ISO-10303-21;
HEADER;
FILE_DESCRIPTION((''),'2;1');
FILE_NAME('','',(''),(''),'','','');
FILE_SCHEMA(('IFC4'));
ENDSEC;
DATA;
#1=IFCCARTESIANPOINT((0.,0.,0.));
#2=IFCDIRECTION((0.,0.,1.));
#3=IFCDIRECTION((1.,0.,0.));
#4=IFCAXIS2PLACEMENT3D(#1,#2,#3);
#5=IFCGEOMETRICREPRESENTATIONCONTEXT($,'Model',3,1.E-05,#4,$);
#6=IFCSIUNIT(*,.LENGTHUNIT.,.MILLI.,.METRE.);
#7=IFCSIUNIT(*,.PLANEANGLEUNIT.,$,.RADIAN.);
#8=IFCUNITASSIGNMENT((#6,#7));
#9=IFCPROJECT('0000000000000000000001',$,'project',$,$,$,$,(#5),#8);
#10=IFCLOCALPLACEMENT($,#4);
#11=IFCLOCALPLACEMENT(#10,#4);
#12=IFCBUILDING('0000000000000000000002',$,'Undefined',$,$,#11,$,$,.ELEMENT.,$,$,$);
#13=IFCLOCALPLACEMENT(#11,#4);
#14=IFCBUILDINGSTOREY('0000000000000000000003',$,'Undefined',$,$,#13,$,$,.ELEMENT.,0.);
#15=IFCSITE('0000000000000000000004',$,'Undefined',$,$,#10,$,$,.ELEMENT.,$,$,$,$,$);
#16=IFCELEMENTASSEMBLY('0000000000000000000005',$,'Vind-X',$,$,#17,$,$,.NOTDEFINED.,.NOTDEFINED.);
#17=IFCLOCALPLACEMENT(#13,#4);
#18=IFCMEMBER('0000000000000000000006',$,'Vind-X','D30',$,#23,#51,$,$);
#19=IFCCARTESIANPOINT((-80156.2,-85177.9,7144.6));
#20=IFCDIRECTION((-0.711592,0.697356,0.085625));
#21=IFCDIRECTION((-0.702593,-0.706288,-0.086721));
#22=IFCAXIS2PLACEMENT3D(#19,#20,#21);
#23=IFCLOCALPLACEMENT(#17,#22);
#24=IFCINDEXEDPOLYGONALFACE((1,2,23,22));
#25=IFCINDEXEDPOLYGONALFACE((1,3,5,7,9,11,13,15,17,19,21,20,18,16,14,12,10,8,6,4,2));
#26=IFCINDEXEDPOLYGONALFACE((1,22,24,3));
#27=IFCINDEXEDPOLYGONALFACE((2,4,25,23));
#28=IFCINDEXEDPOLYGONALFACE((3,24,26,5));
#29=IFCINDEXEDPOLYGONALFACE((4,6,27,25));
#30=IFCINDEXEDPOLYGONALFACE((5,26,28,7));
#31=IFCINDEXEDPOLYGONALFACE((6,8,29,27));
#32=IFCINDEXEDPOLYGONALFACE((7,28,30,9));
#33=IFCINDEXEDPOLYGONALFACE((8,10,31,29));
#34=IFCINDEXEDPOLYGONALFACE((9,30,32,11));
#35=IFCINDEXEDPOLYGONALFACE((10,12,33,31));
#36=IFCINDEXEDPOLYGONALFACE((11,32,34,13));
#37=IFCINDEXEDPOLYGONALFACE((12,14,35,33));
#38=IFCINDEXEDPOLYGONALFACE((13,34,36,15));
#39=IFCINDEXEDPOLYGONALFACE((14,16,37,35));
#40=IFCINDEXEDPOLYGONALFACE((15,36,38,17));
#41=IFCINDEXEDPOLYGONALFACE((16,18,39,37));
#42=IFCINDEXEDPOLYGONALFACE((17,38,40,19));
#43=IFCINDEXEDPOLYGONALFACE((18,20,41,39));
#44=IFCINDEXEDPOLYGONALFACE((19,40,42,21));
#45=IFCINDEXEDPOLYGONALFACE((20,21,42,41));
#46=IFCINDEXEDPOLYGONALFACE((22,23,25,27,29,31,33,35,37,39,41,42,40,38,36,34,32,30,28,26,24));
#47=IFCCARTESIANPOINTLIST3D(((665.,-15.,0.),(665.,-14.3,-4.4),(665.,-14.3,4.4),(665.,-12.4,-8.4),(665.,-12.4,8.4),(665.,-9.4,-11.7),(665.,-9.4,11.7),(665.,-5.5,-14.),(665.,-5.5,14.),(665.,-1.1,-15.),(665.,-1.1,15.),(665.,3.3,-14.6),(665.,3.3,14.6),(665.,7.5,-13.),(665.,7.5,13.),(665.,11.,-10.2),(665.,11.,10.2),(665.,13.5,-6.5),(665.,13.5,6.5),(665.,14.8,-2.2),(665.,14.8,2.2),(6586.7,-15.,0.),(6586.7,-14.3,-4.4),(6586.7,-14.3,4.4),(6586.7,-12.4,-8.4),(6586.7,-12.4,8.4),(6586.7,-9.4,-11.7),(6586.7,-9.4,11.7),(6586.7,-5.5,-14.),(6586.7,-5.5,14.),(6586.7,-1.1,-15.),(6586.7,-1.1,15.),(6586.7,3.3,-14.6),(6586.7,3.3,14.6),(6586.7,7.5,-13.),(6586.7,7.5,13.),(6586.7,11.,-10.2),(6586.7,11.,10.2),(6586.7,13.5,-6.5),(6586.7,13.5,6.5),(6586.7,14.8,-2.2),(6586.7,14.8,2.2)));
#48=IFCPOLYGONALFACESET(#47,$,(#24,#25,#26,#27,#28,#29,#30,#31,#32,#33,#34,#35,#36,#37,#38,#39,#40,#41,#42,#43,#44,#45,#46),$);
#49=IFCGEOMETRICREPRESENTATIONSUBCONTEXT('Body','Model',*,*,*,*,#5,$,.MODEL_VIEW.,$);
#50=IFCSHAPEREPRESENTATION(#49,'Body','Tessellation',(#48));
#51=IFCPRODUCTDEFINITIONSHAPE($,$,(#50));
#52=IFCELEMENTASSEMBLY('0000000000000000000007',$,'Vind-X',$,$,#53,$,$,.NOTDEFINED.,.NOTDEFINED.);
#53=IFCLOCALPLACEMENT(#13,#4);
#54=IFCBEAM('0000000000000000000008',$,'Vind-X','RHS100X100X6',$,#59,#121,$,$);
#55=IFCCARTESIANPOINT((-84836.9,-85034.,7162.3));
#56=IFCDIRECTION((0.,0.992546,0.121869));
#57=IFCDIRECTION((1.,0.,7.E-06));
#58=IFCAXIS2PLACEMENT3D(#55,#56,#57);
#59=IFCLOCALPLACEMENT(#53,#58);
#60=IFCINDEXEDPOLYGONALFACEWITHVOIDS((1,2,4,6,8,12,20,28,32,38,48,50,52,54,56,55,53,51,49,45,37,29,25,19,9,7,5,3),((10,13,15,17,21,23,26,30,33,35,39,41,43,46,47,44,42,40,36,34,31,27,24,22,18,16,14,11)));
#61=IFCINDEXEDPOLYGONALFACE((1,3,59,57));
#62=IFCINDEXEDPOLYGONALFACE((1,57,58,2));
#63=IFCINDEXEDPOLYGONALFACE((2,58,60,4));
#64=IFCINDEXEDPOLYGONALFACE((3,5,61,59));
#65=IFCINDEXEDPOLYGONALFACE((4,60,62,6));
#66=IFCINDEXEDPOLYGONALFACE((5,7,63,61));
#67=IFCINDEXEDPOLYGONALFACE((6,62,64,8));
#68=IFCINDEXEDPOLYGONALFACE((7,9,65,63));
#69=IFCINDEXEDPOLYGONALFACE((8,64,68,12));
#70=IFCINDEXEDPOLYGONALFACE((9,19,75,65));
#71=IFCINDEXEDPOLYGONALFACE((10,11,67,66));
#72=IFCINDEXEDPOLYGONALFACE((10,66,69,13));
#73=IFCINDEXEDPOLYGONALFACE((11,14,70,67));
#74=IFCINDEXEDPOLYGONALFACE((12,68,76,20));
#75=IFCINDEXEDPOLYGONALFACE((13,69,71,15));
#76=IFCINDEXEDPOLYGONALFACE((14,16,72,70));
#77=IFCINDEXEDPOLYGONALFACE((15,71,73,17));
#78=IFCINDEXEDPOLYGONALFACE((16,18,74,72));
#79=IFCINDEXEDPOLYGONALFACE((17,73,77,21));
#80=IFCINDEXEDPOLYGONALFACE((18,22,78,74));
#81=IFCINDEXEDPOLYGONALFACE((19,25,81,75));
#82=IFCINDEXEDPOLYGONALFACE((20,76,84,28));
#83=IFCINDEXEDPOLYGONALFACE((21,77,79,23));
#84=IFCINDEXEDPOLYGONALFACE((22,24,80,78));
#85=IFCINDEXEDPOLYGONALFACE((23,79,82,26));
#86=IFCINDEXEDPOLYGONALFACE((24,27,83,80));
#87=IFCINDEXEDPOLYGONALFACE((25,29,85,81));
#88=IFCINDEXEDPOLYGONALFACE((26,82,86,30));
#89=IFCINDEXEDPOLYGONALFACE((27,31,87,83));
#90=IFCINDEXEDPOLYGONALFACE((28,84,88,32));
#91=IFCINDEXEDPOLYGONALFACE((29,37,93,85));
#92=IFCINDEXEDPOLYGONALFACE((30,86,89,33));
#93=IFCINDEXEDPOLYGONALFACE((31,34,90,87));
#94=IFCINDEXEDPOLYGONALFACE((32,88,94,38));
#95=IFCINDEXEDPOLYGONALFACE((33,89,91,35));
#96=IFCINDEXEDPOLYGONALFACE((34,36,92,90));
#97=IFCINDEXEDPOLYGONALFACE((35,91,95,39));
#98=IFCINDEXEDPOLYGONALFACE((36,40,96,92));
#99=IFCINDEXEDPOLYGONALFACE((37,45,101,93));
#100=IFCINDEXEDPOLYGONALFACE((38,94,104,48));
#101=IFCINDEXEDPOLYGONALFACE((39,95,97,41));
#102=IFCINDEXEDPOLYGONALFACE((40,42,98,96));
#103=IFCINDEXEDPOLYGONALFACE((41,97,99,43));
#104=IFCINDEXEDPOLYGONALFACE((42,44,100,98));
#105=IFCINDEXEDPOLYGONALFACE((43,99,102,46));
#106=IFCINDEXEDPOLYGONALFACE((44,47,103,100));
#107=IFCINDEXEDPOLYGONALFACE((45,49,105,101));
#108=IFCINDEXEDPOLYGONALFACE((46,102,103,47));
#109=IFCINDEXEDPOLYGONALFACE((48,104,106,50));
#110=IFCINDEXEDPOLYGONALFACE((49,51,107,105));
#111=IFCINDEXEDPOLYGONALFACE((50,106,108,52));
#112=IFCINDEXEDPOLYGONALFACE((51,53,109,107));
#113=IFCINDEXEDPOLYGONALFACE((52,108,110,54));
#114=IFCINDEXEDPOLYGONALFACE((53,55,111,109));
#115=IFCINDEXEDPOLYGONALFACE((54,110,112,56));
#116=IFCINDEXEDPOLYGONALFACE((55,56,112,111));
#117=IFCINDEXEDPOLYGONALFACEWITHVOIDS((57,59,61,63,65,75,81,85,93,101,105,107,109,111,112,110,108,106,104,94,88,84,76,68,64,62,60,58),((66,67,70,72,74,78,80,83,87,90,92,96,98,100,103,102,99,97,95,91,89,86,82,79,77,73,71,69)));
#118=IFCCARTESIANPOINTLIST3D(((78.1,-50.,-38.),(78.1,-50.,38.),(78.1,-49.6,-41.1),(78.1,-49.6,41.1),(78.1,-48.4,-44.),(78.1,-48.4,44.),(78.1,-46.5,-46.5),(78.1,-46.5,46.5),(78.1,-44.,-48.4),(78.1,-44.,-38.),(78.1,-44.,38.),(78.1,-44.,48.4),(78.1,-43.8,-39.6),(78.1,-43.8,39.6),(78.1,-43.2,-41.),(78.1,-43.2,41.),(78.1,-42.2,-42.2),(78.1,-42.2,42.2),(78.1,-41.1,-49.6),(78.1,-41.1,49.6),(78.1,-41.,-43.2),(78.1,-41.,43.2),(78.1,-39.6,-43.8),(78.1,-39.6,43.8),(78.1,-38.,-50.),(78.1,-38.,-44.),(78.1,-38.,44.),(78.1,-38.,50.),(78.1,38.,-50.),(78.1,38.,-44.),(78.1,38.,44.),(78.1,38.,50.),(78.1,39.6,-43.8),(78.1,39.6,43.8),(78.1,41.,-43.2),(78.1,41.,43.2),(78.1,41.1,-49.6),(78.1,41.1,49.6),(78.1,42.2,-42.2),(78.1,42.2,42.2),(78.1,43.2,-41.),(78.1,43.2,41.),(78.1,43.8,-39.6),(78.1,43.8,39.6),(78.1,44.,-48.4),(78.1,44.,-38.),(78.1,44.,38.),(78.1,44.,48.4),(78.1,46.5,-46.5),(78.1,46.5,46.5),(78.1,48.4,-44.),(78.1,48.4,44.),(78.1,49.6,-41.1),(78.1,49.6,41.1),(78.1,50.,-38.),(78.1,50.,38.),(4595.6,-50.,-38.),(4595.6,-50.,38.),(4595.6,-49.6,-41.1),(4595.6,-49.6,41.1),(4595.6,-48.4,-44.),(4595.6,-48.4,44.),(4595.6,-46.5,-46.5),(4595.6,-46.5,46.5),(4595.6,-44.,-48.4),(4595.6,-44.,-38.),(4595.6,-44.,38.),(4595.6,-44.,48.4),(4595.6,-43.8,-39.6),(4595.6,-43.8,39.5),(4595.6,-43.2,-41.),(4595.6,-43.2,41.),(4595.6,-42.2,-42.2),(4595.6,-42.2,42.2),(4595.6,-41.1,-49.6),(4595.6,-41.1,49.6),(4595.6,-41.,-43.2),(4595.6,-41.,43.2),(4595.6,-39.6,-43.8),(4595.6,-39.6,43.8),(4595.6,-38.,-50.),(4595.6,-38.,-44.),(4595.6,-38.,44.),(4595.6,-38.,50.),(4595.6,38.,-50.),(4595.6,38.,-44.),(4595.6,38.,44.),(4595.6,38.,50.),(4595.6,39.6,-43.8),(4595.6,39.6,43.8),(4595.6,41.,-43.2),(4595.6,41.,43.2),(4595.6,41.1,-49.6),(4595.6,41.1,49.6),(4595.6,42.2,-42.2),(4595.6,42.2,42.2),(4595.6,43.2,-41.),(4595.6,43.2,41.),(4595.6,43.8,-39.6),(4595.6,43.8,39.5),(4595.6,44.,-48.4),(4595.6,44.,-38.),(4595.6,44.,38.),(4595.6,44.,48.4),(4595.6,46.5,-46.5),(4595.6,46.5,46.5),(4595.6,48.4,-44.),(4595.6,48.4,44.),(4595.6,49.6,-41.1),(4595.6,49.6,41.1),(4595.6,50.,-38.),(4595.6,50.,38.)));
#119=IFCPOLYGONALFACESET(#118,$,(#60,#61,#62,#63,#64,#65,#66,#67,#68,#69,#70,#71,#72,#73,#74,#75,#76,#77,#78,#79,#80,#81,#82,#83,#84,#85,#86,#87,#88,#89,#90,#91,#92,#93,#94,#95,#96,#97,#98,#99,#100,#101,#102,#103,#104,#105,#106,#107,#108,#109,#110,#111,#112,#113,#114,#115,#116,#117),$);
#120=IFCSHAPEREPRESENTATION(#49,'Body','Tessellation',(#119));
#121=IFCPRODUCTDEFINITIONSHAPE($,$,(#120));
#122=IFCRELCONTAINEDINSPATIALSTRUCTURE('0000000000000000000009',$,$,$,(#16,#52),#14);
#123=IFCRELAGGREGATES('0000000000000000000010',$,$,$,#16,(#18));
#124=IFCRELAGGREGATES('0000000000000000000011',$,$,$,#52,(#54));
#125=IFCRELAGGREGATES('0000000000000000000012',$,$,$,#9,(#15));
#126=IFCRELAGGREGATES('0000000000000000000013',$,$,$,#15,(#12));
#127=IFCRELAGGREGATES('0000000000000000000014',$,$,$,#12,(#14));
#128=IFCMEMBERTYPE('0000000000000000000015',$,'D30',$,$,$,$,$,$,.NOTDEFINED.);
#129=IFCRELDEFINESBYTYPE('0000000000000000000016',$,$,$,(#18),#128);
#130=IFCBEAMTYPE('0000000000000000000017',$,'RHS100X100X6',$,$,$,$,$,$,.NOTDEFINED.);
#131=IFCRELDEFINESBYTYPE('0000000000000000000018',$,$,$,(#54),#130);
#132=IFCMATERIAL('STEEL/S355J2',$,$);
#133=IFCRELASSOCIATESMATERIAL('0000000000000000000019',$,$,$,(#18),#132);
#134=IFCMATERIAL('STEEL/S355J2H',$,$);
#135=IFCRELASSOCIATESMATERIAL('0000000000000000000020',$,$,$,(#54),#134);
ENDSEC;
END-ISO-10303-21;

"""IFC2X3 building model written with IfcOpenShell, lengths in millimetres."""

from ifc_helpers import new_model, si_unit, frame, origin_with_axes, origin_2d_with_axis, place, context, subcontext, project, spatial, hollow_rectangle, circle, extrude, clip, halfspace, material, type_object, element, aggregate, save


model = new_model("IFC2X3")

# Units and contexts
model_context = context("Model", 3, precision=1e-05, world=origin_with_axes())
body_context = subcontext(model_context, "Body", "Model", "MODEL_VIEW")
ifc_project = project(units=[si_unit("LENGTHUNIT", "METRE", prefix="MILLI"), si_unit("PLANEANGLEUNIT", "RADIAN")], contexts=[model_context])

# Site, building, storey
site_placement = place(None, origin_with_axes())
site = spatial("IfcSite", under=ifc_project, at=site_placement, Name="Undefined", CompositionType="ELEMENT")
building_placement = place(site_placement, origin_with_axes())
building = spatial("IfcBuilding", under=site, at=building_placement, Name="Undefined", CompositionType="ELEMENT")
storey_placement = place(building_placement, origin_with_axes())
storey = spatial("IfcBuildingStorey", under=building, at=storey_placement, Name="Undefined", CompositionType="ELEMENT", Elevation=0.0)

# Element assembly, member
assembly_1_placement = place(storey_placement, origin_with_axes())
assembly_1 = element("IfcElementAssembly", 1, at=assembly_1_placement, inside=storey, Name="Vind-X", AssemblyPlace="NOTDEFINED", PredefinedType="NOTDEFINED")
ifc_material_1 = material(Name="STEEL/S355J2")
member_type = type_object("IfcMemberType", Name="D30", PredefinedType="NOTDEFINED")
member_placement = place(assembly_1_placement, frame((-80156.2, -85177.9, 7144.6), z_axis=(-0.711592, 0.697356, 0.085625), x_axis=(-0.702593, -0.706288, -0.086721)))
member = element("IfcMember", 2, at=member_placement, type_object=member_type, material=ifc_material_1, Name="Vind-X", Description="D30", context=body_context, shape_type="Clipping", body=[
    clip(clip(extrude(circle(Radius=15.0, at=origin_2d_with_axis()), frame((6671.7, 0.0, 0.0), z_axis=(-1.0, 0.0, 0.0), x_axis=(0.0, -1.0, 0.0)), (0.0, 0.0, 1.0), 6671.7), halfspace(frame((6586.7, 6.0, 16.0), z_axis=(-1.0, 0.0, 0.0), x_axis=(0.0, -1.0, 0.0)), True)), halfspace(frame((665.0, 6.0, 10.2), z_axis=(-1.0, 0.0, 0.0), x_axis=(0.0, -1.0, 0.0)), False)),
])

# Element assembly, beam
assembly_2_placement = place(storey_placement, origin_with_axes())
assembly_2 = element("IfcElementAssembly", 3, at=assembly_2_placement, inside=storey, Name="Vind-X", AssemblyPlace="NOTDEFINED", PredefinedType="NOTDEFINED")
ifc_material_2 = material(Name="STEEL/S355J2H")
beam_type_1 = type_object("IfcBeamType", Name="RHS100X100X6", PredefinedType="NOTDEFINED")
beam_1_placement = place(assembly_2_placement, frame((-84836.9, -85034.0, 7162.3), z_axis=(0.0, 0.992546, 0.121869), x_axis=(1.0, 0.0, 0.000007)))
beam_1 = element("IfcBeam", 4, at=beam_1_placement, type_object=beam_type_1, material=ifc_material_2, Name="Vind-X", Description="RHS100X100X6", context=body_context, shape_type="Clipping", body=[
    clip(clip(extrude(hollow_rectangle(XDim=100.0, YDim=100.0, WallThickness=6.0, InnerFilletRadius=6.0, OuterFilletRadius=12.0, at=origin_2d_with_axis()), frame((4837.2, 0.0, 0.0), z_axis=(-1.0, 0.0, 0.0), x_axis=(0.0, -1.0, 0.0)), (0.0, 0.0, 1.0), 4837.2), halfspace(frame((4595.6, 22.5, 0.0), z_axis=(-1.0, 0.0, 0.0), x_axis=(0.0, 0.0, 1.0)), True)), halfspace(frame((78.1, 22.5, 0.0), z_axis=(1.0, 0.0, 0.0), x_axis=(0.0, 0.0, -1.0)), True)),
])

aggregate(assembly_1, [member])

aggregate(assembly_2, [beam_1])

save(model, "model.ifc")
